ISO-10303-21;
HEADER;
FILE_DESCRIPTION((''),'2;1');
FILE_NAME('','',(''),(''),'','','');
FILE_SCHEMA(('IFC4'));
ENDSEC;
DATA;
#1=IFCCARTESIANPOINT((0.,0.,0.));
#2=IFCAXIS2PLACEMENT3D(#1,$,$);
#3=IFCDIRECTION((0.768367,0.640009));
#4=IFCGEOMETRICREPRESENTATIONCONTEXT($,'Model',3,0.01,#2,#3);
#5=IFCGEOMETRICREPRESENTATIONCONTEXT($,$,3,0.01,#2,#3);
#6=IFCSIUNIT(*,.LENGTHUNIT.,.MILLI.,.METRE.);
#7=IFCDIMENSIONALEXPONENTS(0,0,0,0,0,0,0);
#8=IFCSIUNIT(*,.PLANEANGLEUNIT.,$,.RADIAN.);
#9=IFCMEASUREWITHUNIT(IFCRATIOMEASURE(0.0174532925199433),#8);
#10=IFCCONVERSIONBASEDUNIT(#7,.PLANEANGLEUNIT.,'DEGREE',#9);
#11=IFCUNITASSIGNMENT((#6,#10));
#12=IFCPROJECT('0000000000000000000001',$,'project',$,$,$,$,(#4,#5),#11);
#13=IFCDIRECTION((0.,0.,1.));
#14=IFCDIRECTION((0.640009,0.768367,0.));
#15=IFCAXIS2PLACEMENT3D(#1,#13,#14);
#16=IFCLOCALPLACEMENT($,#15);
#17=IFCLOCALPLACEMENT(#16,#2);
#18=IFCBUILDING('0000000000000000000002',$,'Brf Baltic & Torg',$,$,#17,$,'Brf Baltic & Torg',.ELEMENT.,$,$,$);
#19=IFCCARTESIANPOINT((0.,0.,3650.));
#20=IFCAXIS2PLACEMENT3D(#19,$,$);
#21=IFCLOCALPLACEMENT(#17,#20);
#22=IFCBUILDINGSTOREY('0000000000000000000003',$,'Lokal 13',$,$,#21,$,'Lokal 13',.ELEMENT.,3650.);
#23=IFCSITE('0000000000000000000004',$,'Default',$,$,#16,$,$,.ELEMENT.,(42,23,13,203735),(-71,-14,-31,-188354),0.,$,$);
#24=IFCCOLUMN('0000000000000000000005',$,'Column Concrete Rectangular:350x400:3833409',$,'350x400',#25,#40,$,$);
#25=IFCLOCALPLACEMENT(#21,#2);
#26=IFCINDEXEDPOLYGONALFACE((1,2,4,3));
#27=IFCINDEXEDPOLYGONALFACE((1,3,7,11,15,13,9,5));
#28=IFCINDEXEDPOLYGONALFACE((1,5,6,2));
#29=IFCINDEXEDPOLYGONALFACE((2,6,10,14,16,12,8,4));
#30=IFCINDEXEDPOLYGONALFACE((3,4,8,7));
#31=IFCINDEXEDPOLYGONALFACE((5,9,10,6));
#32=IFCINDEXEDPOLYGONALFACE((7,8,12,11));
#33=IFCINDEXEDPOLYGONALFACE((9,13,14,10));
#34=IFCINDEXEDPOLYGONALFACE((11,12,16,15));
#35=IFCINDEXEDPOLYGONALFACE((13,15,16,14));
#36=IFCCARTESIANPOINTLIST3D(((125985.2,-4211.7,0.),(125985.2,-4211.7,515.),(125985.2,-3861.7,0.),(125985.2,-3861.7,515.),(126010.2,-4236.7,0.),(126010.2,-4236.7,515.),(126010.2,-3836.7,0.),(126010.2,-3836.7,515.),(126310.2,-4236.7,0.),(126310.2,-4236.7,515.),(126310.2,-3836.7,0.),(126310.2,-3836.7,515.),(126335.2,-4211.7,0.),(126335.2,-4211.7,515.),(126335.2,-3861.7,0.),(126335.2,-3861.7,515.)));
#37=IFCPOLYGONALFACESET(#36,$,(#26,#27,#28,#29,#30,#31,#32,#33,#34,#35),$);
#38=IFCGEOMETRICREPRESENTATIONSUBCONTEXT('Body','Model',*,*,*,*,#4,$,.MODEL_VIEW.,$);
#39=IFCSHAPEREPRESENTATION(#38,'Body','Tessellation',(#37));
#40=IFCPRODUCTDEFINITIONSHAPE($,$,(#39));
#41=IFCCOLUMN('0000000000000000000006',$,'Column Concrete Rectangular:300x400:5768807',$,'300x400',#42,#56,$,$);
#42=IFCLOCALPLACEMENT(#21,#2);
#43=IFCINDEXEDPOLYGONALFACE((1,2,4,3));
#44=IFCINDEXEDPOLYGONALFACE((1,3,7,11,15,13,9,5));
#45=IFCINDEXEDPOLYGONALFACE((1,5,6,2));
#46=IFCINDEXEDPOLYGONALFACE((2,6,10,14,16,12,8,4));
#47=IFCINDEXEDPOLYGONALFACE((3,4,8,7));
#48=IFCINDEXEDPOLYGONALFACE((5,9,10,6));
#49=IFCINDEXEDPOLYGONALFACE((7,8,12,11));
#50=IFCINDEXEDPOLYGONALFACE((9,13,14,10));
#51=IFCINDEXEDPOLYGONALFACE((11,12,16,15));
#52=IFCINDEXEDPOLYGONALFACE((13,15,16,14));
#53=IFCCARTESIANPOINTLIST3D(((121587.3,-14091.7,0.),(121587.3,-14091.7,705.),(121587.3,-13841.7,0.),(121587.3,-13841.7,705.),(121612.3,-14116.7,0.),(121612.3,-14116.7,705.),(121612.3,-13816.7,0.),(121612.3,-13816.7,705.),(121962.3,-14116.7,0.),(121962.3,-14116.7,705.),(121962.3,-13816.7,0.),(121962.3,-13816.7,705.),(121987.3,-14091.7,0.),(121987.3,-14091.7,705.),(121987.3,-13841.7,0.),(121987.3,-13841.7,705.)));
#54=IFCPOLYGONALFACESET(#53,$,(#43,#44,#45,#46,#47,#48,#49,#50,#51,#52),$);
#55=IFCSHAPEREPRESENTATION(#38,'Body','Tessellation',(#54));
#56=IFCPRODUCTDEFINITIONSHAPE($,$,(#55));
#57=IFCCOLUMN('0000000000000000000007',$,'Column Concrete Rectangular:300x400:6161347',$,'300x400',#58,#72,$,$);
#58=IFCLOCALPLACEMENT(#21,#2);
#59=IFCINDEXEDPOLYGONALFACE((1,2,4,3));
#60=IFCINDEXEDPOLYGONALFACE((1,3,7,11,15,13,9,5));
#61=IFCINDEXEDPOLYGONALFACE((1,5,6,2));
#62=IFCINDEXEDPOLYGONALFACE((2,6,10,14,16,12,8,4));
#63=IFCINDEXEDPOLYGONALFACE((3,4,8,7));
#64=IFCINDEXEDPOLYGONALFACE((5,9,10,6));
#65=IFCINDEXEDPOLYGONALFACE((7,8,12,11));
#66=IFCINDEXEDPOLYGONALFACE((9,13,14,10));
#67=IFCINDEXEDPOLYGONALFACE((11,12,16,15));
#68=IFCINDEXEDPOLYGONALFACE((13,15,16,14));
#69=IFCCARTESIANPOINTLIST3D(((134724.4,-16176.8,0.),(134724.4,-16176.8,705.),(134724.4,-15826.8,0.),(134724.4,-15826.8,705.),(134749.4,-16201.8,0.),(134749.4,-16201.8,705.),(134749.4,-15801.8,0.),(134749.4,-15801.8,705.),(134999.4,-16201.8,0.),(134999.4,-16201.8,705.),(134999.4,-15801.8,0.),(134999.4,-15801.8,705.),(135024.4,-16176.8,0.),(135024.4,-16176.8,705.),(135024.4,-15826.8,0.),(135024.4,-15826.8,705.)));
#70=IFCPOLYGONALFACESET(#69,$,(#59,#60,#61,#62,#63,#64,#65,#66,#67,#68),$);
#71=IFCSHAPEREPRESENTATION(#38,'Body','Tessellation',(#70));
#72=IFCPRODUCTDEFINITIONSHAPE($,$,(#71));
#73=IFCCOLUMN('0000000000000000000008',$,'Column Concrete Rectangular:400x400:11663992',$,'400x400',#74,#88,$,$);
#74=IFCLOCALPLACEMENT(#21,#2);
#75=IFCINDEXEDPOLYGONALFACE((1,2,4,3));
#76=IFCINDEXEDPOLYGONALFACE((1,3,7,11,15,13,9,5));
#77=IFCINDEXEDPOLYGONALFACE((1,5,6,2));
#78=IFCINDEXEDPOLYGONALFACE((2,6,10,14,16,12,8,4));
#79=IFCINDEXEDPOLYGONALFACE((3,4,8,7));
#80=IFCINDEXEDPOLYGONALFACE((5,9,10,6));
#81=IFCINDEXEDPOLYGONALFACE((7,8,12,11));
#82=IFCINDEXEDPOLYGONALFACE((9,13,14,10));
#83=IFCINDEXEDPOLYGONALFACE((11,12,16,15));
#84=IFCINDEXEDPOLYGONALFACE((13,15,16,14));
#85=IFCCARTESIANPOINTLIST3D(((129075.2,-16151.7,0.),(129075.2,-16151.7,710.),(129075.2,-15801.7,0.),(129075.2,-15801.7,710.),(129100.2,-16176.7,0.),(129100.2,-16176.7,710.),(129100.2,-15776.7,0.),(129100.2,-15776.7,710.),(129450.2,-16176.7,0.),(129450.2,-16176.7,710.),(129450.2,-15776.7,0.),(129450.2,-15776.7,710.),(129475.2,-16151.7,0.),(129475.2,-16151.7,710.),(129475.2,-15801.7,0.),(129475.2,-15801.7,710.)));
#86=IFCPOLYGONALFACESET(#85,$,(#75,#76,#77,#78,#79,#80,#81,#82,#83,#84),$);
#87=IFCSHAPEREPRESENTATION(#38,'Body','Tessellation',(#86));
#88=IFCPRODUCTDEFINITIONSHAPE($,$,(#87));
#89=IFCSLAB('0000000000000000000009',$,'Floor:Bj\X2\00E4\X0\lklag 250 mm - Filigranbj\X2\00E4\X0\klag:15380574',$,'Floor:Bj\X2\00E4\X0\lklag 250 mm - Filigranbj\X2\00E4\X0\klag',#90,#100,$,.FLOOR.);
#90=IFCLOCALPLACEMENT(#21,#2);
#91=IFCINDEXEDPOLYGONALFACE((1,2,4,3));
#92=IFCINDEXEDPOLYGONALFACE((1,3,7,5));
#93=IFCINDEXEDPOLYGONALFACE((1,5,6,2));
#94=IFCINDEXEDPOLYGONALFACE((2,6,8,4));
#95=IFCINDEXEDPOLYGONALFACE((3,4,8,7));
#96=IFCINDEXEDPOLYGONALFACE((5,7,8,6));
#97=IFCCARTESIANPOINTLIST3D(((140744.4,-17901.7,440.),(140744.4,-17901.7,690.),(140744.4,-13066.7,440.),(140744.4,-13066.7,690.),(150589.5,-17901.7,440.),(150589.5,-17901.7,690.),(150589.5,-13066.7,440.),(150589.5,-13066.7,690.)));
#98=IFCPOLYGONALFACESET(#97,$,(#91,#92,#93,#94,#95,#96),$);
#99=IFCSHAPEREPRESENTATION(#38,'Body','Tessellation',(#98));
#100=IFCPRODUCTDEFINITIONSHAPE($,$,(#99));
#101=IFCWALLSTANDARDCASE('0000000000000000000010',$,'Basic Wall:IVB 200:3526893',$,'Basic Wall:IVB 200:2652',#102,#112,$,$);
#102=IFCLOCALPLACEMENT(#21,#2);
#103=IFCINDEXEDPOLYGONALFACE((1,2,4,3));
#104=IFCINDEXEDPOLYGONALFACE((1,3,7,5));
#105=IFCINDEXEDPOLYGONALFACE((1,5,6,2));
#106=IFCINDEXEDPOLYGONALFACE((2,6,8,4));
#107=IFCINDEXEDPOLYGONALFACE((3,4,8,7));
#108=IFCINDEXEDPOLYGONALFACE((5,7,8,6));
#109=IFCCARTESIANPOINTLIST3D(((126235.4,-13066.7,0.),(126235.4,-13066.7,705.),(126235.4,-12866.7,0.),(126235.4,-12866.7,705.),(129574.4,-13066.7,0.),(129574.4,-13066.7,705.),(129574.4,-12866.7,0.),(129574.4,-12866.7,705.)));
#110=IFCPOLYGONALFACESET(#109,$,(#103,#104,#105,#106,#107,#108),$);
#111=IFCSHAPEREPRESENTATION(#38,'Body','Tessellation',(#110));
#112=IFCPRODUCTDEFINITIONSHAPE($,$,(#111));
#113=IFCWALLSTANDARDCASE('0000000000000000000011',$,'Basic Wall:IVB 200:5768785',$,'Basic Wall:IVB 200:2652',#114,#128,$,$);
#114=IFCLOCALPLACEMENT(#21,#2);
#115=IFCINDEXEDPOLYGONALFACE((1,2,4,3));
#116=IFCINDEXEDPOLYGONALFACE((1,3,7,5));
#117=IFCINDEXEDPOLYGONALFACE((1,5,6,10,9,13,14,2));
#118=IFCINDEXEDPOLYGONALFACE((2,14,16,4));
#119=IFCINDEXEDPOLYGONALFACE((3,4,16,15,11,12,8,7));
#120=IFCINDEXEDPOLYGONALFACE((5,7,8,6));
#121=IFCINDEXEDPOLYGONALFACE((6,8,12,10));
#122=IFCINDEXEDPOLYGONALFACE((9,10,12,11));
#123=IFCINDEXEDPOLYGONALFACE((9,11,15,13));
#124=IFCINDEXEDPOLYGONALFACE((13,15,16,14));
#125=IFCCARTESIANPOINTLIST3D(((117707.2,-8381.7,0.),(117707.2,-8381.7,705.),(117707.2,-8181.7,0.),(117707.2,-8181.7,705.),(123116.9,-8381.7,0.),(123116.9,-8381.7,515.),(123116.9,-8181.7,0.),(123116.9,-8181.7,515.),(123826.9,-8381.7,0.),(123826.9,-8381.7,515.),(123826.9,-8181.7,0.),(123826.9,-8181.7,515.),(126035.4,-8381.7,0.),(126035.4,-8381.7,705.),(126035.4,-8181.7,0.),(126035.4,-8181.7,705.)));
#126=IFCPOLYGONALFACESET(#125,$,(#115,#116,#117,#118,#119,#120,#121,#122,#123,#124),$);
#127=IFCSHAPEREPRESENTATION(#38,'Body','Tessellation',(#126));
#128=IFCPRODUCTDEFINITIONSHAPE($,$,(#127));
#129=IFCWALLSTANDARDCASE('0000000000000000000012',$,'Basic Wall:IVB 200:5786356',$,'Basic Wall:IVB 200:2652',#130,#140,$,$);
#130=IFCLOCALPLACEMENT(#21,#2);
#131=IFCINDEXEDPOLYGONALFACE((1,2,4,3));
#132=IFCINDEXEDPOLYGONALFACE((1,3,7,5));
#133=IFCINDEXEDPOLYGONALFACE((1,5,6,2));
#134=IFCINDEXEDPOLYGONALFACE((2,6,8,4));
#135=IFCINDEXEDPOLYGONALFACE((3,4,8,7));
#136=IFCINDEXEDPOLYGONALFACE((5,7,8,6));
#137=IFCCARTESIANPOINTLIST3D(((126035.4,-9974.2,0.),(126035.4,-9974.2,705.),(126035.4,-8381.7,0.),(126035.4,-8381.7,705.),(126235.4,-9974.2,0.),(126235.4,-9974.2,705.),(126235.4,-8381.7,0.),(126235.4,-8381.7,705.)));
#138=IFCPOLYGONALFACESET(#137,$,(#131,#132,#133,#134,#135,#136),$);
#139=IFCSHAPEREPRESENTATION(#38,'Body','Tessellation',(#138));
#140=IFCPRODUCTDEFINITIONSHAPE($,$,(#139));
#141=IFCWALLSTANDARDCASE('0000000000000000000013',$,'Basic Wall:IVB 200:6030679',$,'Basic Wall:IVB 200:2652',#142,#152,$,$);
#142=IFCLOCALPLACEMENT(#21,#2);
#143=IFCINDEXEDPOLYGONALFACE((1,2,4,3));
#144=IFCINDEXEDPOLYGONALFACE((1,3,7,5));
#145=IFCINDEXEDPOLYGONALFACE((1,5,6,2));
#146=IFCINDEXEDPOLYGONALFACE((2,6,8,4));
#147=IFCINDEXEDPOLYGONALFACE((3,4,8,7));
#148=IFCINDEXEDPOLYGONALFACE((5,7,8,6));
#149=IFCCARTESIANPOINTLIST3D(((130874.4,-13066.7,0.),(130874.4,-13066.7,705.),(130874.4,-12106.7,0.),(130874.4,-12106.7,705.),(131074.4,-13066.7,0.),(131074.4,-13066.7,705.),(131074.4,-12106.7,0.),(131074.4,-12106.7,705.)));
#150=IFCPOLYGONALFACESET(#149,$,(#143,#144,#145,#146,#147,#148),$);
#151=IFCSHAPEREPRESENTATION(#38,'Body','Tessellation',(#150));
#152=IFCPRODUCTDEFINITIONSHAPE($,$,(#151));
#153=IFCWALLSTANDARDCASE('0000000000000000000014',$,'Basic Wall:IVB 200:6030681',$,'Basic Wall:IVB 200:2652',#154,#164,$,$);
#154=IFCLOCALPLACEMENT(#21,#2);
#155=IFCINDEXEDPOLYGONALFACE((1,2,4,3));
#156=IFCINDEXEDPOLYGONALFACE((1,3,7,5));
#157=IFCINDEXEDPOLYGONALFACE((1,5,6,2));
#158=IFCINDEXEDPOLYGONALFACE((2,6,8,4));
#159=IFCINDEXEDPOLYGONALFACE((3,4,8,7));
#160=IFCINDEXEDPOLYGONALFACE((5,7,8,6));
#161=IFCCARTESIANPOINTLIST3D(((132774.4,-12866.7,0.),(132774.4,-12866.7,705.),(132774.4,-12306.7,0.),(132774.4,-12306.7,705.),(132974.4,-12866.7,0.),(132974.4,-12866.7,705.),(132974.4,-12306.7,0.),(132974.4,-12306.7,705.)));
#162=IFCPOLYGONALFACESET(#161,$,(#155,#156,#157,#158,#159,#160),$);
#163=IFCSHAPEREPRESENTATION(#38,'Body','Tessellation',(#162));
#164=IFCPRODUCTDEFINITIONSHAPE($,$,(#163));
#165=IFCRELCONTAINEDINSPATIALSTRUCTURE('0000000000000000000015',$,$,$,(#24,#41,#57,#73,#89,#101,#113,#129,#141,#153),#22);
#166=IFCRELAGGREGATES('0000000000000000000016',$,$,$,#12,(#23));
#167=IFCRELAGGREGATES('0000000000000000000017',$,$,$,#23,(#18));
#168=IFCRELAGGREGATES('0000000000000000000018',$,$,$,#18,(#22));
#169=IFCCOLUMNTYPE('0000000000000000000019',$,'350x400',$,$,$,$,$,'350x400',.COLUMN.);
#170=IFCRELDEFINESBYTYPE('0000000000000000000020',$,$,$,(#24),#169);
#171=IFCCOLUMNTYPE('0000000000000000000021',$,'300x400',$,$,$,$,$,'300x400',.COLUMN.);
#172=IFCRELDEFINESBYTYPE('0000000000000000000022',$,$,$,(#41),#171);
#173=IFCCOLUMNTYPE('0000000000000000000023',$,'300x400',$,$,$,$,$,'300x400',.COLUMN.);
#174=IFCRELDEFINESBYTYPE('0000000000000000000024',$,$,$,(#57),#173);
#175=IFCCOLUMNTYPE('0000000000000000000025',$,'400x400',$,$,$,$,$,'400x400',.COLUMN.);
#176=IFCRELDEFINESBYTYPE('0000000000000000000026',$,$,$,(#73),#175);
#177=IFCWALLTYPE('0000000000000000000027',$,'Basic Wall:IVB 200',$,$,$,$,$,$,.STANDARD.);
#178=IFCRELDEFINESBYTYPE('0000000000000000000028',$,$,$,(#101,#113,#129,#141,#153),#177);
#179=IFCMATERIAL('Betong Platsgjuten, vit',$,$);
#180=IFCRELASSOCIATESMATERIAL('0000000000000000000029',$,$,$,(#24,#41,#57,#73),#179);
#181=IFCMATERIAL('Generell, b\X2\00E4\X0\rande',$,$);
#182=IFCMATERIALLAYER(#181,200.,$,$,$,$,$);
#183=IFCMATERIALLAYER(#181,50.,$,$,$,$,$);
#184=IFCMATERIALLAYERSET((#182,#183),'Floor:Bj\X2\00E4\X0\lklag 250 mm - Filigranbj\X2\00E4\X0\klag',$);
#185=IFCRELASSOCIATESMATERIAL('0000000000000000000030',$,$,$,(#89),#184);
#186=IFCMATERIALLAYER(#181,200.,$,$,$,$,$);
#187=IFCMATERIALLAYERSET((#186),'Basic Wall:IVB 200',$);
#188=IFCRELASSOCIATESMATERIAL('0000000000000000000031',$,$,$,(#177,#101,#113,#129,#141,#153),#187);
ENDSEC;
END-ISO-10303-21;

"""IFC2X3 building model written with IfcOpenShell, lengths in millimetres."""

from ifc_helpers import new_model, entity, si_unit, converted_unit, direction, frame, frame_2d, origin, place, context, subcontext, project, spatial, polyline, rectangle, outline, extrude, clip, halfspace, bounded_halfspace, source, transform, mapped, material, layer, layer_set, layer_usage, type_object, type_shapes, element, save


model = new_model("IFC2X3")

# Units and contexts
model_context = context("Model", 3, precision=0.01, world=origin(), true_north=direction((0.768367, 0.640009)))
context_of_model = context(None, 3, precision=0.01, world=origin(), true_north=direction((0.768367, 0.640009)))
body_context = subcontext(model_context, "Body", "Model", "MODEL_VIEW")
ifc_project = project(units=[si_unit("LENGTHUNIT", "METRE", prefix="MILLI"), converted_unit("PLANEANGLEUNIT", "DEGREE", entity("IfcRatioMeasure", 0.0174532925199433), si_unit("PLANEANGLEUNIT", "RADIAN"), dimensions=[0, 0, 0, 0, 0, 0, 0])], contexts=[model_context, context_of_model])

# Site, building, storey
site_placement = place(None, frame((0.0, 0.0, 0.0), z_axis=(0.0, 0.0, 1.0), x_axis=(0.640009, 0.768367, 0.0)))
site = spatial("IfcSite", under=ifc_project, at=site_placement, Name="Default", CompositionType="ELEMENT", RefLatitude=(42, 23, 13, 203735), RefLongitude=(-71, -14, -31, -188354), RefElevation=0.0)
building_placement = place(site_placement, origin())
building = spatial("IfcBuilding", under=site, at=building_placement, Name="Brf Baltic & Torg", LongName="Brf Baltic & Torg", CompositionType="ELEMENT")
storey_placement = place(building_placement, frame((0.0, 0.0, 3650.0)))
storey = spatial("IfcBuildingStorey", under=building, at=storey_placement, Name="Lokal 13", LongName="Lokal 13", CompositionType="ELEMENT", Elevation=3650.0)

# Columns
ifc_material_1 = material(Name="Betong Platsgjuten, vit")
column_type_1 = type_object("IfcColumnType", Name="350x400", ElementType="350x400", PredefinedType="COLUMN")
shared_shape_1 = source(origin(), body_context, "Body", "SweptSolid", [
    extrude(outline(polyline([(-175.0, -175.0), (175.0, -175.0), (200.0, -150.0), (200.0, 150.0), (175.0, 175.0), (-175.0, 175.0), (-200.0, 150.0), (-200.0, -150.0), (-175.0, -175.0)])), frame((0.0, 0.0, 3650.0), z_axis=(0.0, 0.0, 1.0), x_axis=(0.0, -1.0, 0.0)), (0.0, 0.0, 1.0), 515.0),
])
type_shapes(column_type_1, [shared_shape_1])
column_1_placement = place(storey_placement, frame((126160.2, -4036.7, -3650.0)))
element("IfcColumn", 1, at=column_1_placement, inside=storey, type_object=column_type_1, material=ifc_material_1, Name="Column Concrete Rectangular:350x400:3833409", ObjectType="350x400", context=body_context, shape_type="MappedRepresentation", body=[
    mapped(shared_shape_1, transform((0.0, 0.0, 0.0), scale=1.0)),
])
column_type_2 = type_object("IfcColumnType", Name="300x400", ElementType="300x400", PredefinedType="COLUMN")
shared_shape_2 = source(origin(), body_context, "Body", "SweptSolid", [
    extrude(outline(polyline([(-175.0, -150.0), (175.0, -150.0), (200.0, -125.0), (200.0, 125.0), (175.0, 150.0), (-175.0, 150.0), (-200.0, 125.0), (-200.0, -125.0), (-175.0, -150.0)])), frame((0.0, 0.0, 3650.0), z_axis=(0.0, 0.0, 1.0), x_axis=(0.0, -1.0, 0.0)), (0.0, 0.0, 1.0), 705.0),
])
type_shapes(column_type_2, [shared_shape_2])
column_2_placement = place(storey_placement, frame((121787.3, -13966.7, -3650.0), z_axis=(0.0, 0.0, 1.0), x_axis=(0.0, 1.0, 0.0)))
element("IfcColumn", 2, at=column_2_placement, inside=storey, type_object=column_type_2, material=ifc_material_1, Name="Column Concrete Rectangular:300x400:5768807", ObjectType="300x400", context=body_context, shape_type="MappedRepresentation", body=[
    mapped(shared_shape_2, transform((0.0, 0.0, 0.0), scale=1.0)),
])
column_type_3 = type_object("IfcColumnType", Name="300x400", ElementType="300x400", PredefinedType="COLUMN")
shared_shape_3 = source(origin(), body_context, "Body", "SweptSolid", [
    extrude(outline(polyline([(-175.0, -150.0), (175.0, -150.0), (200.0, -125.0), (200.0, 125.0), (175.0, 150.0), (-175.0, 150.0), (-200.0, 125.0), (-200.0, -125.0), (-175.0, -150.0)])), frame((0.0, 0.0, 3650.0), z_axis=(0.0, 0.0, 1.0), x_axis=(0.0, -1.0, 0.0)), (0.0, 0.0, 1.0), 705.0),
])
type_shapes(column_type_3, [shared_shape_3])
column_3_placement = place(storey_placement, frame((134874.4, -16001.8, -3650.0)))
element("IfcColumn", 3, at=column_3_placement, inside=storey, type_object=column_type_3, material=ifc_material_1, Name="Column Concrete Rectangular:300x400:6161347", ObjectType="300x400", context=body_context, shape_type="MappedRepresentation", body=[
    mapped(shared_shape_3, transform((0.0, 0.0, 0.0), scale=1.0)),
])
column_type_4 = type_object("IfcColumnType", Name="400x400", ElementType="400x400", PredefinedType="COLUMN")
shared_shape_4 = source(origin(), body_context, "Body", "SweptSolid", [
    extrude(outline(polyline([(-175.0, -200.0), (175.0, -200.0), (200.0, -175.0), (200.0, 175.0), (175.0, 200.0), (-175.0, 200.0), (-200.0, 175.0), (-200.0, -175.0), (-175.0, -200.0)])), frame((0.0, 0.0, 3650.0), z_axis=(0.0, 0.0, 1.0), x_axis=(0.0, -1.0, 0.0)), (0.0, 0.0, 1.0), 710.0),
])
type_shapes(column_type_4, [shared_shape_4])
column_4_placement = place(storey_placement, frame((129275.2, -15976.7, -3650.0)))
element("IfcColumn", 4, at=column_4_placement, inside=storey, type_object=column_type_4, material=ifc_material_1, Name="Column Concrete Rectangular:400x400:11663992", ObjectType="400x400", context=body_context, shape_type="MappedRepresentation", body=[
    mapped(shared_shape_4, transform((0.0, 0.0, 0.0), scale=1.0)),
])

# Slab
ifc_material_2 = material(Name="Generell, bärande")
ifc_layer_1 = layer(ifc_material_2, 200.0)
ifc_layer_2 = layer(ifc_material_2, 50.0)
ifc_layer_set_1 = layer_set([ifc_layer_1, ifc_layer_2], Name="Floor:Bjälklag 250 mm - Filigranbjäklag")
ifc_layer_usage_1 = layer_usage(ifc_layer_set_1, "AXIS3", "POSITIVE", 0.0)
slab_1_placement = place(storey_placement, origin())
element("IfcSlab", 5, at=slab_1_placement, inside=storey, material=ifc_layer_usage_1, Name="Floor:Bjälklag 250 mm - Filigranbjäklag:15380574", ObjectType="Floor:Bjälklag 250 mm - Filigranbjäklag", PredefinedType="FLOOR", context=body_context, shape_type="SweptSolid", body=[
    extrude(rectangle(XDim=4835.0, YDim=9845.1, at=frame_2d((0.0, 0.0), x_axis=(1.0, 0.0))), frame((145667.0, -15484.2, 690.0), z_axis=(0.0, 0.0, -1.0), x_axis=(0.0, 1.0, 0.0)), (0.0, 0.0, 1.0), 250.0),
])

# Shared definitions
ifc_layer_3 = layer(ifc_material_2, 200.0)
ifc_layer_set_2 = layer_set([ifc_layer_3], Name="Basic Wall:IVB 200")
wall_type = type_object("IfcWallType", Name="Basic Wall:IVB 200", PredefinedType="STANDARD", material=ifc_layer_set_2)

# Wall
ifc_layer_usage_2 = layer_usage(ifc_layer_set_2, "AXIS2", "NEGATIVE", 100.0)
wall_1_placement = place(storey_placement, frame((129574.4, -12966.7, 0.0), z_axis=(0.0, 0.0, 1.0), x_axis=(-1.0, 0.0, 0.0)))
element("IfcWallStandardCase", 6, at=wall_1_placement, inside=storey, type_object=wall_type, material=ifc_layer_usage_2, Name="Basic Wall:IVB 200:3526893", ObjectType="Basic Wall:IVB 200:2652", context=body_context, shape_type="Clipping", body=[
    clip(extrude(rectangle(XDim=3339.0, YDim=200.0, at=frame_2d((1669.5, 0.0), x_axis=(-1.0, 0.0))), origin(), (0.0, 0.0, 1.0), 705.0), halfspace(frame((0.0, 0.0, -2000.0)), True)),
])

# Wall, opening
ifc_layer_usage_3 = layer_usage(ifc_layer_set_2, "AXIS2", "POSITIVE", -100.0)
wall_2_placement = place(storey_placement, frame((126035.4, -8281.7, 0.0), z_axis=(0.0, 0.0, 1.0), x_axis=(-1.0, 0.000006, 0.0)))
wall_2 = element("IfcWallStandardCase", 7, at=wall_2_placement, inside=storey, type_object=wall_type, material=ifc_layer_usage_3, Name="Basic Wall:IVB 200:5768785", ObjectType="Basic Wall:IVB 200:2652", context=body_context, shape_type="Clipping", body=[
    clip(clip(extrude(rectangle(XDim=8328.2, YDim=200.0, at=frame_2d((4164.1, 0.0), x_axis=(-1.0, 0.0))), origin(), (0.0, 0.0, 1.0), 705.0), bounded_halfspace(frame((0.0, 100.0, 705.0), z_axis=(0.0, 0.0, -1.0), x_axis=(0.000006, -1.0, 0.0)), True, frame((0.0, 100.0, 705.0)), polyline([(0.0, 0.0), (0.0, -200.0), (8328.2, -200.0), (8328.2, 0.0), (4172.7, 0.0), (3118.6, 0.0), (2918.6, 0.0), (0.0, 0.0)]))), halfspace(frame((0.0, 0.0, -2000.0)), True)),
])
opening_1_placement = place(wall_2_placement, frame((126035.4, -8281.7, -2000.0), z_axis=(0.0, 0.0, 1.0), x_axis=(-1.0, 0.0, 0.0)))
element("IfcOpeningElement", 8, at=opening_1_placement, cuts=wall_2, ObjectType="Opening", context=body_context, shape_type="SweptSolid", body=[
    extrude(rectangle(XDim=1710.0, YDim=710.0, at=frame_2d((0.0, 0.0), x_axis=(0.0, 1.0))), frame((123471.9, -6857.7, 1660.0), z_axis=(-0.000006, -1.0, 0.0), x_axis=(1.0, -0.000006, 0.0)), (0.0, 0.0, 1.0), 3048.0),
])

# Walls
ifc_layer_usage_4 = layer_usage(ifc_layer_set_2, "AXIS2", "NEGATIVE", 100.0)
wall_3_placement = place(storey_placement, frame((126135.4, -9974.2, 0.0), z_axis=(0.0, 0.0, 1.0), x_axis=(0.0, 1.0, 0.0)))
element("IfcWallStandardCase", 9, at=wall_3_placement, inside=storey, type_object=wall_type, material=ifc_layer_usage_4, Name="Basic Wall:IVB 200:5786356", ObjectType="Basic Wall:IVB 200:2652", context=body_context, shape_type="Clipping", body=[
    clip(clip(extrude(rectangle(XDim=1592.5, YDim=200.0, at=frame_2d((796.3, 0.0), x_axis=(-1.0, 0.0))), origin(), (0.0, 0.0, 1.0), 705.0), bounded_halfspace(frame((0.0, -100.0, 705.0), z_axis=(0.0, 0.0, -1.0), x_axis=(1.0, 0.0, 0.0)), True, frame((0.0, -100.0, 705.0)), polyline([(0.0, 0.0), (1592.5, 0.0), (1592.5, 200.0), (0.0, 200.0), (0.0, 0.0)]))), halfspace(frame((0.0, 0.0, -2000.0)), True)),
])
ifc_layer_usage_5 = layer_usage(ifc_layer_set_2, "AXIS2", "POSITIVE", -100.0)
wall_4_placement = place(storey_placement, frame((130974.4, -13066.7, 0.0), z_axis=(0.0, 0.0, 1.0), x_axis=(0.0, 1.0, 0.0)))
element("IfcWallStandardCase", 10, at=wall_4_placement, inside=storey, type_object=wall_type, material=ifc_layer_usage_5, Name="Basic Wall:IVB 200:6030679", ObjectType="Basic Wall:IVB 200:2652", context=body_context, shape_type="Clipping", body=[
    clip(extrude(rectangle(XDim=960.0, YDim=200.0, at=frame_2d((480.0, 0.0), x_axis=(-1.0, 0.0))), origin(), (0.0, 0.0, 1.0), 705.0), halfspace(frame((0.0, 0.0, -2000.0)), True)),
])

# Wall
ifc_layer_usage_6 = layer_usage(ifc_layer_set_2, "AXIS2", "POSITIVE", -100.0)
wall_5_placement = place(storey_placement, frame((132874.4, -12866.7, 0.0), z_axis=(0.0, 0.0, 1.0), x_axis=(0.0, 1.0, 0.0)))
element("IfcWallStandardCase", 11, at=wall_5_placement, inside=storey, type_object=wall_type, material=ifc_layer_usage_6, Name="Basic Wall:IVB 200:6030681", ObjectType="Basic Wall:IVB 200:2652", context=body_context, shape_type="Clipping", body=[
    clip(extrude(rectangle(XDim=560.0, YDim=200.0, at=frame_2d((280.0, 0.0), x_axis=(-1.0, 0.0))), origin(), (0.0, 0.0, 1.0), 705.0), halfspace(frame((0.0, 0.0, -2000.0)), True)),
])

save(model, "model.ifc")
